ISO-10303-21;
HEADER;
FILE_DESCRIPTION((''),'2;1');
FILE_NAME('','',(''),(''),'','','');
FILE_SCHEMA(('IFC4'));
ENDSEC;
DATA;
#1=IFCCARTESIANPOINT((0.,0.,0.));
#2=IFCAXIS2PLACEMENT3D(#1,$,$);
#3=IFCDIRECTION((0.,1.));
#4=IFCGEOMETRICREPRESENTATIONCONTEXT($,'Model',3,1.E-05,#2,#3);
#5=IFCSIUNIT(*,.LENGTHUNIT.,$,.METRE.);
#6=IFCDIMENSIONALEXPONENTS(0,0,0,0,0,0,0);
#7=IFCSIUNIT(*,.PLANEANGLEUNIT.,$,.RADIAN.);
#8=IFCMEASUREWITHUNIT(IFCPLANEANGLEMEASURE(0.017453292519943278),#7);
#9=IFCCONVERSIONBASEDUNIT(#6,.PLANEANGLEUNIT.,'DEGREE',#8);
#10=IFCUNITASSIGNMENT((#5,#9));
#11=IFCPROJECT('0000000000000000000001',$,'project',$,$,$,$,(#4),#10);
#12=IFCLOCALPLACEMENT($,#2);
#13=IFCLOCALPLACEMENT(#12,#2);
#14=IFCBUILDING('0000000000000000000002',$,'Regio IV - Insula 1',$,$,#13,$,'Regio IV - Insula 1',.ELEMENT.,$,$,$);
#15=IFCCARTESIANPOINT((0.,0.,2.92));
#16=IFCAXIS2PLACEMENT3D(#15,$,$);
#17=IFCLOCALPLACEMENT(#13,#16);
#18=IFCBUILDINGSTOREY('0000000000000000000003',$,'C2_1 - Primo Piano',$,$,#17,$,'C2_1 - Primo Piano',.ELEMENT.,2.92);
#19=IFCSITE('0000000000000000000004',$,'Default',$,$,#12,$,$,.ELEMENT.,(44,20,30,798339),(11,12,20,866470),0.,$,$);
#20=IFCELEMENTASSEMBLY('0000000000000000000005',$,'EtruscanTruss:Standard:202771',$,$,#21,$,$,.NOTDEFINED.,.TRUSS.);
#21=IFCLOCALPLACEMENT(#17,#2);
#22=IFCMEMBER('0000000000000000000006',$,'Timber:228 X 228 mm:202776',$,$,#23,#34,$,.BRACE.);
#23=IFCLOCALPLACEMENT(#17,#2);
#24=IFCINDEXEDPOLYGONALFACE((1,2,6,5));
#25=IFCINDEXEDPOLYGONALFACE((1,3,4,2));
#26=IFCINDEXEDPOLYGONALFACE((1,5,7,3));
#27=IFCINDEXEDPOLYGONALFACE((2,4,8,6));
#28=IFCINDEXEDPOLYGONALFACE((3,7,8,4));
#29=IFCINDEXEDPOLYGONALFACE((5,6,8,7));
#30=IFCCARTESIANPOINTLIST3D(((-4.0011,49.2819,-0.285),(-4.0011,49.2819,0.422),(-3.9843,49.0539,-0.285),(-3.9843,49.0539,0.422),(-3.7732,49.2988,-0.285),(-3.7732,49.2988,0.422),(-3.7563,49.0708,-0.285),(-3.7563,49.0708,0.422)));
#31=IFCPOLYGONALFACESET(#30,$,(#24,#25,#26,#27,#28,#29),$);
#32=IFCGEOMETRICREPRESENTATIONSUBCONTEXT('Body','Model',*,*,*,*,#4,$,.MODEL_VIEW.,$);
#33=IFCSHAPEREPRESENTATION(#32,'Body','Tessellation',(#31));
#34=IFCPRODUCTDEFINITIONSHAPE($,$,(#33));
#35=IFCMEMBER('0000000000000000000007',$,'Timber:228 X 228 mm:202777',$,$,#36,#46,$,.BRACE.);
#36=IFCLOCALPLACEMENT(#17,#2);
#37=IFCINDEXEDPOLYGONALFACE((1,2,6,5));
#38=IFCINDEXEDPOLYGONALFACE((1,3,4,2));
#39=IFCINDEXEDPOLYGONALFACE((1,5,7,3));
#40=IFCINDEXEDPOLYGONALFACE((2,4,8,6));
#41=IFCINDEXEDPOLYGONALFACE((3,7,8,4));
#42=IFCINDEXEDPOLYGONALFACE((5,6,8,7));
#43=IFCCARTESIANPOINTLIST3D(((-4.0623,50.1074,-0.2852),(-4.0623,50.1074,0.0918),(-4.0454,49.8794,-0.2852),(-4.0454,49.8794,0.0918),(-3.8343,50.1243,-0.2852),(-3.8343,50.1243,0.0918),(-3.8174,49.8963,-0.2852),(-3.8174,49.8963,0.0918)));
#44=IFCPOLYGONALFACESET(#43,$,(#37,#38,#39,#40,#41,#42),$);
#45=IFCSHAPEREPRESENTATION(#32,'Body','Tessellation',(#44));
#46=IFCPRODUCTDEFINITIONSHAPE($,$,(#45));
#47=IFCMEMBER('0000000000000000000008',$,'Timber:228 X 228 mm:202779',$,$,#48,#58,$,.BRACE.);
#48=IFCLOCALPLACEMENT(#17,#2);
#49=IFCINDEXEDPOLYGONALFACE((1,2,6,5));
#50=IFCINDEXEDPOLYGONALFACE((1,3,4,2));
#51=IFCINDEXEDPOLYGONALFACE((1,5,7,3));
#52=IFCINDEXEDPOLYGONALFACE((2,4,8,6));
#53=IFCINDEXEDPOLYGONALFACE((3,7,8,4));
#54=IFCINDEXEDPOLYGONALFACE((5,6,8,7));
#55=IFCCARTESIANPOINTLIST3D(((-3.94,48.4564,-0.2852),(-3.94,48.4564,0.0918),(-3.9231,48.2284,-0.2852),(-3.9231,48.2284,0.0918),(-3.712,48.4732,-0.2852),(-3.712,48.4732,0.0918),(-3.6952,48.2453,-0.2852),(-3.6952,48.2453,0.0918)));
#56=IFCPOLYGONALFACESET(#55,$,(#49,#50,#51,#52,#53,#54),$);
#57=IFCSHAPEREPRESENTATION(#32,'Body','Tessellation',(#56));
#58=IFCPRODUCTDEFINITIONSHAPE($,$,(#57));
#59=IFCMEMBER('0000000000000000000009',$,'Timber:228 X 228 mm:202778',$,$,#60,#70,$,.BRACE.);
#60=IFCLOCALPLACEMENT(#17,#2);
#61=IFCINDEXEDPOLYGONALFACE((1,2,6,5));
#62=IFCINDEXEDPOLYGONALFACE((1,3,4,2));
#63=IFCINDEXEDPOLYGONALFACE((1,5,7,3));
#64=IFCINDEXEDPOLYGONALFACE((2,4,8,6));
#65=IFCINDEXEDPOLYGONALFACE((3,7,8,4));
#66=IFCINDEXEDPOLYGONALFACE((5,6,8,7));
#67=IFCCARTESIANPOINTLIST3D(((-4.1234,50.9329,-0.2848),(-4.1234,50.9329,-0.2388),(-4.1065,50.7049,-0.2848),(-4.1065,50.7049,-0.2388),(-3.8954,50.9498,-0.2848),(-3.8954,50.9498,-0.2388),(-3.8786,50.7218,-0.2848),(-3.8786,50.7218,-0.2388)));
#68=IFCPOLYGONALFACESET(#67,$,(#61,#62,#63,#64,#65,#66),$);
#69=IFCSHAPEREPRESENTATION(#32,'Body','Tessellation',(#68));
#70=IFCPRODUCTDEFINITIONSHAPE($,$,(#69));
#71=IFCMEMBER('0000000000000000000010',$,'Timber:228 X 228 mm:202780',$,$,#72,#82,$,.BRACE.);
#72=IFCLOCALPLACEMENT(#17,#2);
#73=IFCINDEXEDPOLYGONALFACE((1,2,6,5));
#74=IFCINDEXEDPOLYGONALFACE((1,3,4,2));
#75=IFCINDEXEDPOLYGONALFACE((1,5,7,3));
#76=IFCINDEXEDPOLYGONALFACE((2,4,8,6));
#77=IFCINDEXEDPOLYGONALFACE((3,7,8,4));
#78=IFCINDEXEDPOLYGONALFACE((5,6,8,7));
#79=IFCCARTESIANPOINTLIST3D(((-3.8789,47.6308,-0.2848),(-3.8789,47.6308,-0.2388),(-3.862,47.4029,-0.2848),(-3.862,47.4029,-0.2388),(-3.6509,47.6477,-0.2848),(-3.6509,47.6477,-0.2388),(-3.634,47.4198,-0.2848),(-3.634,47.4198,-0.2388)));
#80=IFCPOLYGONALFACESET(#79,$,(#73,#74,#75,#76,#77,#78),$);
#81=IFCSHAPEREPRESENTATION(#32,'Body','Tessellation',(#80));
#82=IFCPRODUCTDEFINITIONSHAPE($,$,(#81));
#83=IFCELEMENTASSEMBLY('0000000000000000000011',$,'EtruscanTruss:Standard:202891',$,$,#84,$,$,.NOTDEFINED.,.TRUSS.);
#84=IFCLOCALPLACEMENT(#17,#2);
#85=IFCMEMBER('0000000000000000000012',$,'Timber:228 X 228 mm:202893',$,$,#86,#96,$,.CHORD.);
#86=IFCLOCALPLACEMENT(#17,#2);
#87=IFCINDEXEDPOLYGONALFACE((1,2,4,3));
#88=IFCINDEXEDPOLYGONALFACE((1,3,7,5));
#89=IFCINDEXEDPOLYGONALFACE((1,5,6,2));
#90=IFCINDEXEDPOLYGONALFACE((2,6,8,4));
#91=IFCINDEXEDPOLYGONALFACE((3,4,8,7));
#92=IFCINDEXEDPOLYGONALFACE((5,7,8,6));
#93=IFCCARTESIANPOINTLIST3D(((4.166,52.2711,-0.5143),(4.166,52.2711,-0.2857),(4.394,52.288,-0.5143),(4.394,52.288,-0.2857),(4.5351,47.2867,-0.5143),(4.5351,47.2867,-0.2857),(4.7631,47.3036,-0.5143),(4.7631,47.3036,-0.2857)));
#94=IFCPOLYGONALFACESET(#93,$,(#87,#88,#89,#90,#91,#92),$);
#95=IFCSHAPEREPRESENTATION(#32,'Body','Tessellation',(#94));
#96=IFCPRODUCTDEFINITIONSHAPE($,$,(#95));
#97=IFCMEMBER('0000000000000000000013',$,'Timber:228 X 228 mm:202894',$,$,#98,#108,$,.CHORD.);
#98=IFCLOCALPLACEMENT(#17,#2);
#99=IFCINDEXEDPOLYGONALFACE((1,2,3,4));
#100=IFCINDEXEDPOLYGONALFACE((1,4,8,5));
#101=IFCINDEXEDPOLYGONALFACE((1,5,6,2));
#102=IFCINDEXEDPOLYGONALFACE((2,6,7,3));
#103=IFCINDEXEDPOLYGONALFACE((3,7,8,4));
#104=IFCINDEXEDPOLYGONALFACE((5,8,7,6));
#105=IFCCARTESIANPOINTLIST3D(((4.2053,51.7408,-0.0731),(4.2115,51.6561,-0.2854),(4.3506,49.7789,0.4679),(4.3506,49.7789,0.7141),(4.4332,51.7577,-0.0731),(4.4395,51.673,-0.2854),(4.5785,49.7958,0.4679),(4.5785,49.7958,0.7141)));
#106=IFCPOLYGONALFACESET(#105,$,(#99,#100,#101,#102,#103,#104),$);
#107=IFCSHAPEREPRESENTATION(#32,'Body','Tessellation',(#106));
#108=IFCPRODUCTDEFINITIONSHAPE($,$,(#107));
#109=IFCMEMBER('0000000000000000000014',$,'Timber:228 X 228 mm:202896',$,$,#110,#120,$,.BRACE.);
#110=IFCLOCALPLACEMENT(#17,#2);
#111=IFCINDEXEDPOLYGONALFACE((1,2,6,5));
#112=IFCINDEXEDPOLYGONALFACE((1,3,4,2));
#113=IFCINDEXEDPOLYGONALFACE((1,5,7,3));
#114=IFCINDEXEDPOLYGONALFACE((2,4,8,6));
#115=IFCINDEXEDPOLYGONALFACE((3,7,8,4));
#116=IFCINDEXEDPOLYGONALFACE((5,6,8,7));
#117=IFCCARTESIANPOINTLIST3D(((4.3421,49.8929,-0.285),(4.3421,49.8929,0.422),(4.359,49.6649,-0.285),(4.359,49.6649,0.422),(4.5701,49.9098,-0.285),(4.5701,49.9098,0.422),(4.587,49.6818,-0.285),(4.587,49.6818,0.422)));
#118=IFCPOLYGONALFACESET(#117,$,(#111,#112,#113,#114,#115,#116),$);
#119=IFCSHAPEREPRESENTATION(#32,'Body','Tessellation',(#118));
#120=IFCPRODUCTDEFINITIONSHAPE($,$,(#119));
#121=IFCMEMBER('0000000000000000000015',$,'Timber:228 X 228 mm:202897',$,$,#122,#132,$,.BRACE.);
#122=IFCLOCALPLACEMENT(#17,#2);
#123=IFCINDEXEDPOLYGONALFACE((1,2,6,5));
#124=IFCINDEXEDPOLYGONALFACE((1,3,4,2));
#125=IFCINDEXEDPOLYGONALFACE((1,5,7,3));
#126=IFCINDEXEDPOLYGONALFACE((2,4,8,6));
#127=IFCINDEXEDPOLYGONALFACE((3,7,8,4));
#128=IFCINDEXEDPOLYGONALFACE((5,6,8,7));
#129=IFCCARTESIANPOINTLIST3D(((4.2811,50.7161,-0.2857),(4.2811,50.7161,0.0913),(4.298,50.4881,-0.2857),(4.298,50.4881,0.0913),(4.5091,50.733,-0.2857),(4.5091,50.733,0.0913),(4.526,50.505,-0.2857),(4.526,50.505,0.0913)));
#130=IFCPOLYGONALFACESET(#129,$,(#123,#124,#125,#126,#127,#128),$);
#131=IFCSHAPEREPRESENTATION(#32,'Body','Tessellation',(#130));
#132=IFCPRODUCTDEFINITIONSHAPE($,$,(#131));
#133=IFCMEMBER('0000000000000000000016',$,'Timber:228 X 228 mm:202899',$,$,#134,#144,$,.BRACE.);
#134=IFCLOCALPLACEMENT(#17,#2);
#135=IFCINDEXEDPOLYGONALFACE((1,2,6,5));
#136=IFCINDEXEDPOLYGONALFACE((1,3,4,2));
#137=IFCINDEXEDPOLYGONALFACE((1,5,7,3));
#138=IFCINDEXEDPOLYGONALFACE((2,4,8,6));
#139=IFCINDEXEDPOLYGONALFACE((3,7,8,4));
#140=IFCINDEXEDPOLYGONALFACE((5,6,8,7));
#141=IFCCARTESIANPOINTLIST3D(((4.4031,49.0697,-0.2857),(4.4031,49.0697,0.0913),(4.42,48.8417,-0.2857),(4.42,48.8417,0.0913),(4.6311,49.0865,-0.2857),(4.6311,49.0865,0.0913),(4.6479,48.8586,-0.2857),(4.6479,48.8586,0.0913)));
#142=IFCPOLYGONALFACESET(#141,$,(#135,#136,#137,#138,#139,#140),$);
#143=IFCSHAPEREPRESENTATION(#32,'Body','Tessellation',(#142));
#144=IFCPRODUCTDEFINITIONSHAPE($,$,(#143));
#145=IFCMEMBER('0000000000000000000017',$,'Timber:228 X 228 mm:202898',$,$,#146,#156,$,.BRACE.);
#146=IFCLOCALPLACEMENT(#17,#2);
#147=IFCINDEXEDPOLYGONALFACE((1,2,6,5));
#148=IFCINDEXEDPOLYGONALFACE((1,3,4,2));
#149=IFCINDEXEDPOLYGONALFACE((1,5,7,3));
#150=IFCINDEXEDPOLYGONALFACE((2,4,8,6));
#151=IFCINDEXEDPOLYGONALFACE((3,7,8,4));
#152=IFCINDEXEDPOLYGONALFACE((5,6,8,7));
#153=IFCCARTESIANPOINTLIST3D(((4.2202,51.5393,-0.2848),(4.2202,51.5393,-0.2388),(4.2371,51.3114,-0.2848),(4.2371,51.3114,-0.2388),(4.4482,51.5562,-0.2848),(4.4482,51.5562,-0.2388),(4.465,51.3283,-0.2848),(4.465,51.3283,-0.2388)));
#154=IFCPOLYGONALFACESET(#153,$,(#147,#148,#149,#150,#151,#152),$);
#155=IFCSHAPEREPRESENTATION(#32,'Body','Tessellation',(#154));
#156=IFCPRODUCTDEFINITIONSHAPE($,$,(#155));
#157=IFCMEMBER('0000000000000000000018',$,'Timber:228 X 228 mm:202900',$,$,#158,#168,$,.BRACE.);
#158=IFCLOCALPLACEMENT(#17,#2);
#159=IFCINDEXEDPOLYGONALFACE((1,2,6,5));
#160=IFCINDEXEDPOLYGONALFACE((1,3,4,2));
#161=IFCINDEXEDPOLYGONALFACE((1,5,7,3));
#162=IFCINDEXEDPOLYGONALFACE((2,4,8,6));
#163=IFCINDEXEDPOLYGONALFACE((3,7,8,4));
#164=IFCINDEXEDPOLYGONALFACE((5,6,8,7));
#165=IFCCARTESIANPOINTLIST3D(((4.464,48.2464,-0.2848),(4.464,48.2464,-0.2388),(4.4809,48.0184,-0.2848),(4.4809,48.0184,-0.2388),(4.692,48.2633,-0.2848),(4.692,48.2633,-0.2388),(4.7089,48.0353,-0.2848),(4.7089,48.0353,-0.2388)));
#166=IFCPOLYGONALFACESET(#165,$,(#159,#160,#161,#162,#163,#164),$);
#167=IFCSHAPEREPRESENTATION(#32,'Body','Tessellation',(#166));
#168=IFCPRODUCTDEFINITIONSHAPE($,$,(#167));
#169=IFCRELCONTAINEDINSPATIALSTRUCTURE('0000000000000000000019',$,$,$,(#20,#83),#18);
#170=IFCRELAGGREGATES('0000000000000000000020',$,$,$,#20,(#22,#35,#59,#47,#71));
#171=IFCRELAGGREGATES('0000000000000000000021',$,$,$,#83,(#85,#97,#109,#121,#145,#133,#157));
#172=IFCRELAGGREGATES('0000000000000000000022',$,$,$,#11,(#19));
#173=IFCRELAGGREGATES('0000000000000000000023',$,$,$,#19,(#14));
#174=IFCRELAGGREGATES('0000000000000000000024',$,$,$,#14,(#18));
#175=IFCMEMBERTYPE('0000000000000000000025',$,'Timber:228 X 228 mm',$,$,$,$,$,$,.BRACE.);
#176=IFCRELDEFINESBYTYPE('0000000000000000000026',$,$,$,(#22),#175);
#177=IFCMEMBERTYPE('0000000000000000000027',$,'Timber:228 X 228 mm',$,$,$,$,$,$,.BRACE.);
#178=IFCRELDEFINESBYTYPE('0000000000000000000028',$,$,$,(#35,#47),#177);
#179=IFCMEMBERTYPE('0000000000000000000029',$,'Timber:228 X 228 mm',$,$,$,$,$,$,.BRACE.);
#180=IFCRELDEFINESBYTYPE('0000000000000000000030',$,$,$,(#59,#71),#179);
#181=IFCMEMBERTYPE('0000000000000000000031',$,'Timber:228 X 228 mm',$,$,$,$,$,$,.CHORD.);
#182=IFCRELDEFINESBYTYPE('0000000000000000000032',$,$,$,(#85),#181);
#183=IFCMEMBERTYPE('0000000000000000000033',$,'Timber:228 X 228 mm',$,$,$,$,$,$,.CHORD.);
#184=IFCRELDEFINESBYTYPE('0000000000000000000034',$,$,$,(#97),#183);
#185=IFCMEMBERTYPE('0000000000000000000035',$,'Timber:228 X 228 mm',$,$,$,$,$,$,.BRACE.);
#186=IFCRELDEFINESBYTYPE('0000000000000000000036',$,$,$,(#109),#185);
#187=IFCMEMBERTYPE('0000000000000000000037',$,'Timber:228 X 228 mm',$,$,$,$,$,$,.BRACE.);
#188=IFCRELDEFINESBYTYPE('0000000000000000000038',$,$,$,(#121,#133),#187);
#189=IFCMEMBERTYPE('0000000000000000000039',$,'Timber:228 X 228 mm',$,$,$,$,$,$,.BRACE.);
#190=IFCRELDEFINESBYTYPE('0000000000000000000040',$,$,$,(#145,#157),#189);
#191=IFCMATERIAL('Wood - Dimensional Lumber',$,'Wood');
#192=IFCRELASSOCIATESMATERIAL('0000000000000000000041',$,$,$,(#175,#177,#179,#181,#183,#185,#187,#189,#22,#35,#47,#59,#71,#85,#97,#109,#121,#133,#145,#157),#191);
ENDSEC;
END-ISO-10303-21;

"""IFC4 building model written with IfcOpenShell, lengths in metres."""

from ifc_helpers import new_model, entity, si_unit, converted_unit, direction, frame, frame_2d, origin, origin_2d_with_axis, place, context, subcontext, project, spatial, rectangle, extrude, clip, halfspace, source, transform, mapped, material, material_profile, profile_set, profile_usage, type_object, type_shapes, element, aggregate, save


model = new_model("IFC4")

# Units and contexts
model_context = context("Model", 3, precision=1e-05, world=origin(), true_north=direction((0.0, 1.0)))
body_context = subcontext(model_context, "Body", "Model", "MODEL_VIEW")
ifc_project = project(units=[si_unit("LENGTHUNIT", "METRE"), converted_unit("PLANEANGLEUNIT", "DEGREE", entity("IfcPlaneAngleMeasure", 0.017453292519943278), si_unit("PLANEANGLEUNIT", "RADIAN"), dimensions=[0, 0, 0, 0, 0, 0, 0])], contexts=[model_context])

# Site, building, storey
site_placement = place(None, origin())
site = spatial("IfcSite", under=ifc_project, at=site_placement, Name="Default", CompositionType="ELEMENT", RefLatitude=(44, 20, 30, 798339), RefLongitude=(11, 12, 20, 866470), RefElevation=0.0)
building_placement = place(site_placement, origin())
building = spatial("IfcBuilding", under=site, at=building_placement, Name="Regio IV - Insula 1", LongName="Regio IV - Insula 1", CompositionType="ELEMENT")
storey_placement = place(building_placement, frame((0.0, 0.0, 2.92)))
storey = spatial("IfcBuildingStorey", under=building, at=storey_placement, Name="C2_1 - Primo Piano", LongName="C2_1 - Primo Piano", CompositionType="ELEMENT", Elevation=2.92)

# Shared definitions
ifc_material_1 = material(Name="Wood - Dimensional Lumber", Category="Wood")
ifc_material_profile = material_profile(ifc_material_1, rectangle(XDim=8.091, YDim=0.2286, at=frame_2d((0.0, 0.0), x_axis=(1.0, 0.0))), Name="228 X 228 mm")
ifc_profile_set = profile_set([ifc_material_profile], Name="228 X 228 mm")

# Shared definitions
ifc_profile_usage_1 = profile_usage(ifc_profile_set)

# Element assemblies, members
assembly_1_placement = place(storey_placement, origin())
assembly_1 = element("IfcElementAssembly", 1, at=assembly_1_placement, inside=storey, Name="EtruscanTruss:Standard:202771", AssemblyPlace="NOTDEFINED", PredefinedType="TRUSS")
member_type_1 = type_object("IfcMemberType", Name="Timber:228 X 228 mm", PredefinedType="BRACE", material=ifc_profile_set)
shared_shape_1 = source(origin(), body_context, "Body", "SweptSolid", [
    extrude(rectangle(XDim=0.707, YDim=0.2286, at=origin_2d_with_axis()), frame((-0.027, 0.0, -0.1143), z_axis=(0.0, 0.0, 1.0), x_axis=(-1.0, 0.0, 0.0)), (0.0, 0.0, 1.0), 0.2286),
])
type_shapes(member_type_1, [shared_shape_1])
member_1_placement = place(assembly_1_placement, frame((-3.8787, 49.1763, 0.0955), z_axis=(0.073857, -0.997269, 0.0), x_axis=(0.0, 0.0, 1.0)))
member_1 = element("IfcMember", 2, at=member_1_placement, type_object=member_type_1, material=ifc_profile_usage_1, Name="Timber:228 X 228 mm:202776", PredefinedType="BRACE", context=body_context, shape_type="MappedRepresentation", body=[
    mapped(shared_shape_1, transform((0.0, 0.0, 0.0), scale=1.0)),
])
member_type_2 = type_object("IfcMemberType", Name="Timber:228 X 228 mm", PredefinedType="BRACE", material=ifc_profile_set)
shared_shape_2 = source(origin(), body_context, "Body", "SweptSolid", [
    extrude(rectangle(XDim=0.377, YDim=0.2286, at=frame_2d((0.0, 0.0), x_axis=(1.0, 0.0))), frame((-0.027, 0.0, -0.1143), z_axis=(0.0, 0.0, 1.0), x_axis=(-1.0, 0.0, 0.0)), (0.0, 0.0, 1.0), 0.2286),
])
type_shapes(member_type_2, [shared_shape_2])
member_2_placement = place(assembly_1_placement, frame((-3.9399, 50.0018, -0.0697), z_axis=(0.073857, -0.997269, 0.0), x_axis=(0.0, 0.0, 1.0)))
member_2 = element("IfcMember", 3, at=member_2_placement, type_object=member_type_2, material=ifc_profile_usage_1, Name="Timber:228 X 228 mm:202777", PredefinedType="BRACE", context=body_context, shape_type="MappedRepresentation", body=[
    mapped(shared_shape_2, transform((0.0, 0.0, 0.0), scale=1.0)),
])
member_3_placement = place(assembly_1_placement, frame((-3.8176, 48.3508, -0.0697), z_axis=(0.073857, -0.997269, 0.0), x_axis=(0.0, 0.0, 1.0)))
member_3 = element("IfcMember", 4, at=member_3_placement, type_object=member_type_2, material=ifc_profile_usage_1, Name="Timber:228 X 228 mm:202779", PredefinedType="BRACE", context=body_context, shape_type="MappedRepresentation", body=[
    mapped(shared_shape_2, transform((0.0, 0.0, 0.0), scale=1.0)),
])
member_type_3 = type_object("IfcMemberType", Name="Timber:228 X 228 mm", PredefinedType="BRACE", material=ifc_profile_set)
shared_shape_3 = source(origin(), body_context, "Body", "SweptSolid", [
    extrude(rectangle(XDim=0.046, YDim=0.2286, at=origin_2d_with_axis()), frame((-0.027, 0.0, -0.1143), z_axis=(0.0, 0.0, 1.0), x_axis=(-1.0, 0.0, 0.0)), (0.0, 0.0, 1.0), 0.2286),
])
type_shapes(member_type_3, [shared_shape_3])
member_4_placement = place(assembly_1_placement, frame((-4.001, 50.8274, -0.2348), z_axis=(0.073857, -0.997269, 0.0), x_axis=(0.0, 0.0, 1.0)))
member_4 = element("IfcMember", 5, at=member_4_placement, type_object=member_type_3, material=ifc_profile_usage_1, Name="Timber:228 X 228 mm:202778", PredefinedType="BRACE", context=body_context, shape_type="MappedRepresentation", body=[
    mapped(shared_shape_3, transform((0.0, 0.0, 0.0), scale=1.0)),
])
member_5_placement = place(assembly_1_placement, frame((-3.7564, 47.5253, -0.2348), z_axis=(0.073857, -0.997269, 0.0), x_axis=(0.0, 0.0, 1.0)))
member_5 = element("IfcMember", 6, at=member_5_placement, type_object=member_type_3, material=ifc_profile_usage_1, Name="Timber:228 X 228 mm:202780", PredefinedType="BRACE", context=body_context, shape_type="MappedRepresentation", body=[
    mapped(shared_shape_3, transform((0.0, 0.0, 0.0), scale=1.0)),
])
aggregate(assembly_1, [member_1, member_2, member_4, member_3, member_5])
assembly_2_placement = place(storey_placement, origin())
assembly_2 = element("IfcElementAssembly", 7, at=assembly_2_placement, inside=storey, Name="EtruscanTruss:Standard:202891", AssemblyPlace="NOTDEFINED", PredefinedType="TRUSS")
member_type_4 = type_object("IfcMemberType", Name="Timber:228 X 228 mm", PredefinedType="CHORD", material=ifc_profile_set)
shared_shape_4 = source(origin(), body_context, "Body", "SweptSolid", [
    extrude(rectangle(XDim=4.998, YDim=0.2286, at=origin_2d_with_axis()), frame((0.0, 0.0, -0.1143), z_axis=(0.0, 0.0, 1.0), x_axis=(-1.0, 0.0, 0.0)), (0.0, 0.0, 1.0), 0.2286),
])
type_shapes(member_type_4, [shared_shape_4])
member_6_placement = place(assembly_2_placement, frame((4.4645, 49.7873, -0.4), z_axis=(0.0, 0.0, 1.0), x_axis=(0.073857, -0.997269, 0.0)))
member_6 = element("IfcMember", 8, at=member_6_placement, type_object=member_type_4, material=ifc_profile_usage_1, Name="Timber:228 X 228 mm:202893", PredefinedType="CHORD", context=body_context, shape_type="MappedRepresentation", body=[
    mapped(shared_shape_4, transform((0.0, 0.0, 0.0), scale=1.0)),
])
member_type_5 = type_object("IfcMemberType", Name="Timber:228 X 228 mm", PredefinedType="CHORD", material=ifc_profile_set)
shared_shape_5 = source(origin(), body_context, "Body", "Clipping", [
    clip(extrude(rectangle(XDim=0.2286, YDim=0.2286, at=frame_2d((0.0, 0.0), x_axis=(0.0, 1.0))), frame((4.3224, 51.7069, 2.7408), z_axis=(0.06857, -0.925887, 0.371527), x_axis=(-0.997269, -0.073857, 0.0)), (0.0, 0.0, 1.0), 2.1189), halfspace(frame((4.4645, 49.7873, 3.6341), z_axis=(0.073857, -0.997269, 0.0), x_axis=(0.997269, 0.073857, 0.0)), False)),
])
type_shapes(member_type_5, [shared_shape_5])
member_7_placement = place(assembly_2_placement, frame((0.0, 0.0, -2.92)))
member_7 = element("IfcMember", 9, at=member_7_placement, type_object=member_type_5, material=ifc_profile_usage_1, Name="Timber:228 X 228 mm:202894", PredefinedType="CHORD", context=body_context, shape_type="MappedRepresentation", body=[
    mapped(shared_shape_5, transform((0.0, 0.0, 0.0), scale=1.0)),
])
member_type_6 = type_object("IfcMemberType", Name="Timber:228 X 228 mm", PredefinedType="BRACE", material=ifc_profile_set)
shared_shape_6 = source(origin(), body_context, "Body", "SweptSolid", [
    extrude(rectangle(XDim=0.707, YDim=0.2286, at=origin_2d_with_axis()), frame((-0.027, 0.0, -0.1143), z_axis=(0.0, 0.0, 1.0), x_axis=(-1.0, 0.0, 0.0)), (0.0, 0.0, 1.0), 0.2286),
])
type_shapes(member_type_6, [shared_shape_6])
member_8_placement = place(assembly_2_placement, frame((4.4645, 49.7873, 0.0955), z_axis=(0.073857, -0.997269, 0.0), x_axis=(0.0, 0.0, 1.0)))
member_8 = element("IfcMember", 10, at=member_8_placement, type_object=member_type_6, material=ifc_profile_usage_1, Name="Timber:228 X 228 mm:202896", PredefinedType="BRACE", context=body_context, shape_type="MappedRepresentation", body=[
    mapped(shared_shape_6, transform((0.0, 0.0, 0.0), scale=1.0)),
])
member_type_7 = type_object("IfcMemberType", Name="Timber:228 X 228 mm", PredefinedType="BRACE", material=ifc_profile_set)
shared_shape_7 = source(origin(), body_context, "Body", "SweptSolid", [
    extrude(rectangle(XDim=0.377, YDim=0.2286, at=origin_2d_with_axis()), frame((-0.0275, 0.0, -0.1143), z_axis=(0.0, 0.0, 1.0), x_axis=(-1.0, 0.0, 0.0)), (0.0, 0.0, 1.0), 0.2286),
])
type_shapes(member_type_7, [shared_shape_7])
member_9_placement = place(assembly_2_placement, frame((4.4036, 50.6106, -0.0697), z_axis=(0.073857, -0.997269, 0.0), x_axis=(0.0, 0.0, 1.0)))
member_9 = element("IfcMember", 11, at=member_9_placement, type_object=member_type_7, material=ifc_profile_usage_1, Name="Timber:228 X 228 mm:202897", PredefinedType="BRACE", context=body_context, shape_type="MappedRepresentation", body=[
    mapped(shared_shape_7, transform((0.0, 0.0, 0.0), scale=1.0)),
])
member_10_placement = place(assembly_2_placement, frame((4.5255, 48.9641, -0.0697), z_axis=(0.073857, -0.997269, 0.0), x_axis=(0.0, 0.0, 1.0)))
member_10 = element("IfcMember", 12, at=member_10_placement, type_object=member_type_7, material=ifc_profile_usage_1, Name="Timber:228 X 228 mm:202899", PredefinedType="BRACE", context=body_context, shape_type="MappedRepresentation", body=[
    mapped(shared_shape_7, transform((0.0, 0.0, 0.0), scale=1.0)),
])
member_type_8 = type_object("IfcMemberType", Name="Timber:228 X 228 mm", PredefinedType="BRACE", material=ifc_profile_set)
shared_shape_8 = source(origin(), body_context, "Body", "SweptSolid", [
    extrude(rectangle(XDim=0.046, YDim=0.2286, at=origin_2d_with_axis()), frame((-0.027, 0.0, -0.1143), z_axis=(0.0, 0.0, 1.0), x_axis=(-1.0, 0.0, 0.0)), (0.0, 0.0, 1.0), 0.2286),
])
type_shapes(member_type_8, [shared_shape_8])
member_11_placement = place(assembly_2_placement, frame((4.3426, 51.4338, -0.2348), z_axis=(0.073857, -0.997269, 0.0), x_axis=(0.0, 0.0, 1.0)))
member_11 = element("IfcMember", 13, at=member_11_placement, type_object=member_type_8, material=ifc_profile_usage_1, Name="Timber:228 X 228 mm:202898", PredefinedType="BRACE", context=body_context, shape_type="MappedRepresentation", body=[
    mapped(shared_shape_8, transform((0.0, 0.0, 0.0), scale=1.0)),
])
member_12_placement = place(assembly_2_placement, frame((4.5865, 48.1409, -0.2348), z_axis=(0.073857, -0.997269, 0.0), x_axis=(0.0, 0.0, 1.0)))
member_12 = element("IfcMember", 14, at=member_12_placement, type_object=member_type_8, material=ifc_profile_usage_1, Name="Timber:228 X 228 mm:202900", PredefinedType="BRACE", context=body_context, shape_type="MappedRepresentation", body=[
    mapped(shared_shape_8, transform((0.0, 0.0, 0.0), scale=1.0)),
])
aggregate(assembly_2, [member_6, member_7, member_8, member_9, member_11, member_10, member_12])

save(model, "model.ifc")
